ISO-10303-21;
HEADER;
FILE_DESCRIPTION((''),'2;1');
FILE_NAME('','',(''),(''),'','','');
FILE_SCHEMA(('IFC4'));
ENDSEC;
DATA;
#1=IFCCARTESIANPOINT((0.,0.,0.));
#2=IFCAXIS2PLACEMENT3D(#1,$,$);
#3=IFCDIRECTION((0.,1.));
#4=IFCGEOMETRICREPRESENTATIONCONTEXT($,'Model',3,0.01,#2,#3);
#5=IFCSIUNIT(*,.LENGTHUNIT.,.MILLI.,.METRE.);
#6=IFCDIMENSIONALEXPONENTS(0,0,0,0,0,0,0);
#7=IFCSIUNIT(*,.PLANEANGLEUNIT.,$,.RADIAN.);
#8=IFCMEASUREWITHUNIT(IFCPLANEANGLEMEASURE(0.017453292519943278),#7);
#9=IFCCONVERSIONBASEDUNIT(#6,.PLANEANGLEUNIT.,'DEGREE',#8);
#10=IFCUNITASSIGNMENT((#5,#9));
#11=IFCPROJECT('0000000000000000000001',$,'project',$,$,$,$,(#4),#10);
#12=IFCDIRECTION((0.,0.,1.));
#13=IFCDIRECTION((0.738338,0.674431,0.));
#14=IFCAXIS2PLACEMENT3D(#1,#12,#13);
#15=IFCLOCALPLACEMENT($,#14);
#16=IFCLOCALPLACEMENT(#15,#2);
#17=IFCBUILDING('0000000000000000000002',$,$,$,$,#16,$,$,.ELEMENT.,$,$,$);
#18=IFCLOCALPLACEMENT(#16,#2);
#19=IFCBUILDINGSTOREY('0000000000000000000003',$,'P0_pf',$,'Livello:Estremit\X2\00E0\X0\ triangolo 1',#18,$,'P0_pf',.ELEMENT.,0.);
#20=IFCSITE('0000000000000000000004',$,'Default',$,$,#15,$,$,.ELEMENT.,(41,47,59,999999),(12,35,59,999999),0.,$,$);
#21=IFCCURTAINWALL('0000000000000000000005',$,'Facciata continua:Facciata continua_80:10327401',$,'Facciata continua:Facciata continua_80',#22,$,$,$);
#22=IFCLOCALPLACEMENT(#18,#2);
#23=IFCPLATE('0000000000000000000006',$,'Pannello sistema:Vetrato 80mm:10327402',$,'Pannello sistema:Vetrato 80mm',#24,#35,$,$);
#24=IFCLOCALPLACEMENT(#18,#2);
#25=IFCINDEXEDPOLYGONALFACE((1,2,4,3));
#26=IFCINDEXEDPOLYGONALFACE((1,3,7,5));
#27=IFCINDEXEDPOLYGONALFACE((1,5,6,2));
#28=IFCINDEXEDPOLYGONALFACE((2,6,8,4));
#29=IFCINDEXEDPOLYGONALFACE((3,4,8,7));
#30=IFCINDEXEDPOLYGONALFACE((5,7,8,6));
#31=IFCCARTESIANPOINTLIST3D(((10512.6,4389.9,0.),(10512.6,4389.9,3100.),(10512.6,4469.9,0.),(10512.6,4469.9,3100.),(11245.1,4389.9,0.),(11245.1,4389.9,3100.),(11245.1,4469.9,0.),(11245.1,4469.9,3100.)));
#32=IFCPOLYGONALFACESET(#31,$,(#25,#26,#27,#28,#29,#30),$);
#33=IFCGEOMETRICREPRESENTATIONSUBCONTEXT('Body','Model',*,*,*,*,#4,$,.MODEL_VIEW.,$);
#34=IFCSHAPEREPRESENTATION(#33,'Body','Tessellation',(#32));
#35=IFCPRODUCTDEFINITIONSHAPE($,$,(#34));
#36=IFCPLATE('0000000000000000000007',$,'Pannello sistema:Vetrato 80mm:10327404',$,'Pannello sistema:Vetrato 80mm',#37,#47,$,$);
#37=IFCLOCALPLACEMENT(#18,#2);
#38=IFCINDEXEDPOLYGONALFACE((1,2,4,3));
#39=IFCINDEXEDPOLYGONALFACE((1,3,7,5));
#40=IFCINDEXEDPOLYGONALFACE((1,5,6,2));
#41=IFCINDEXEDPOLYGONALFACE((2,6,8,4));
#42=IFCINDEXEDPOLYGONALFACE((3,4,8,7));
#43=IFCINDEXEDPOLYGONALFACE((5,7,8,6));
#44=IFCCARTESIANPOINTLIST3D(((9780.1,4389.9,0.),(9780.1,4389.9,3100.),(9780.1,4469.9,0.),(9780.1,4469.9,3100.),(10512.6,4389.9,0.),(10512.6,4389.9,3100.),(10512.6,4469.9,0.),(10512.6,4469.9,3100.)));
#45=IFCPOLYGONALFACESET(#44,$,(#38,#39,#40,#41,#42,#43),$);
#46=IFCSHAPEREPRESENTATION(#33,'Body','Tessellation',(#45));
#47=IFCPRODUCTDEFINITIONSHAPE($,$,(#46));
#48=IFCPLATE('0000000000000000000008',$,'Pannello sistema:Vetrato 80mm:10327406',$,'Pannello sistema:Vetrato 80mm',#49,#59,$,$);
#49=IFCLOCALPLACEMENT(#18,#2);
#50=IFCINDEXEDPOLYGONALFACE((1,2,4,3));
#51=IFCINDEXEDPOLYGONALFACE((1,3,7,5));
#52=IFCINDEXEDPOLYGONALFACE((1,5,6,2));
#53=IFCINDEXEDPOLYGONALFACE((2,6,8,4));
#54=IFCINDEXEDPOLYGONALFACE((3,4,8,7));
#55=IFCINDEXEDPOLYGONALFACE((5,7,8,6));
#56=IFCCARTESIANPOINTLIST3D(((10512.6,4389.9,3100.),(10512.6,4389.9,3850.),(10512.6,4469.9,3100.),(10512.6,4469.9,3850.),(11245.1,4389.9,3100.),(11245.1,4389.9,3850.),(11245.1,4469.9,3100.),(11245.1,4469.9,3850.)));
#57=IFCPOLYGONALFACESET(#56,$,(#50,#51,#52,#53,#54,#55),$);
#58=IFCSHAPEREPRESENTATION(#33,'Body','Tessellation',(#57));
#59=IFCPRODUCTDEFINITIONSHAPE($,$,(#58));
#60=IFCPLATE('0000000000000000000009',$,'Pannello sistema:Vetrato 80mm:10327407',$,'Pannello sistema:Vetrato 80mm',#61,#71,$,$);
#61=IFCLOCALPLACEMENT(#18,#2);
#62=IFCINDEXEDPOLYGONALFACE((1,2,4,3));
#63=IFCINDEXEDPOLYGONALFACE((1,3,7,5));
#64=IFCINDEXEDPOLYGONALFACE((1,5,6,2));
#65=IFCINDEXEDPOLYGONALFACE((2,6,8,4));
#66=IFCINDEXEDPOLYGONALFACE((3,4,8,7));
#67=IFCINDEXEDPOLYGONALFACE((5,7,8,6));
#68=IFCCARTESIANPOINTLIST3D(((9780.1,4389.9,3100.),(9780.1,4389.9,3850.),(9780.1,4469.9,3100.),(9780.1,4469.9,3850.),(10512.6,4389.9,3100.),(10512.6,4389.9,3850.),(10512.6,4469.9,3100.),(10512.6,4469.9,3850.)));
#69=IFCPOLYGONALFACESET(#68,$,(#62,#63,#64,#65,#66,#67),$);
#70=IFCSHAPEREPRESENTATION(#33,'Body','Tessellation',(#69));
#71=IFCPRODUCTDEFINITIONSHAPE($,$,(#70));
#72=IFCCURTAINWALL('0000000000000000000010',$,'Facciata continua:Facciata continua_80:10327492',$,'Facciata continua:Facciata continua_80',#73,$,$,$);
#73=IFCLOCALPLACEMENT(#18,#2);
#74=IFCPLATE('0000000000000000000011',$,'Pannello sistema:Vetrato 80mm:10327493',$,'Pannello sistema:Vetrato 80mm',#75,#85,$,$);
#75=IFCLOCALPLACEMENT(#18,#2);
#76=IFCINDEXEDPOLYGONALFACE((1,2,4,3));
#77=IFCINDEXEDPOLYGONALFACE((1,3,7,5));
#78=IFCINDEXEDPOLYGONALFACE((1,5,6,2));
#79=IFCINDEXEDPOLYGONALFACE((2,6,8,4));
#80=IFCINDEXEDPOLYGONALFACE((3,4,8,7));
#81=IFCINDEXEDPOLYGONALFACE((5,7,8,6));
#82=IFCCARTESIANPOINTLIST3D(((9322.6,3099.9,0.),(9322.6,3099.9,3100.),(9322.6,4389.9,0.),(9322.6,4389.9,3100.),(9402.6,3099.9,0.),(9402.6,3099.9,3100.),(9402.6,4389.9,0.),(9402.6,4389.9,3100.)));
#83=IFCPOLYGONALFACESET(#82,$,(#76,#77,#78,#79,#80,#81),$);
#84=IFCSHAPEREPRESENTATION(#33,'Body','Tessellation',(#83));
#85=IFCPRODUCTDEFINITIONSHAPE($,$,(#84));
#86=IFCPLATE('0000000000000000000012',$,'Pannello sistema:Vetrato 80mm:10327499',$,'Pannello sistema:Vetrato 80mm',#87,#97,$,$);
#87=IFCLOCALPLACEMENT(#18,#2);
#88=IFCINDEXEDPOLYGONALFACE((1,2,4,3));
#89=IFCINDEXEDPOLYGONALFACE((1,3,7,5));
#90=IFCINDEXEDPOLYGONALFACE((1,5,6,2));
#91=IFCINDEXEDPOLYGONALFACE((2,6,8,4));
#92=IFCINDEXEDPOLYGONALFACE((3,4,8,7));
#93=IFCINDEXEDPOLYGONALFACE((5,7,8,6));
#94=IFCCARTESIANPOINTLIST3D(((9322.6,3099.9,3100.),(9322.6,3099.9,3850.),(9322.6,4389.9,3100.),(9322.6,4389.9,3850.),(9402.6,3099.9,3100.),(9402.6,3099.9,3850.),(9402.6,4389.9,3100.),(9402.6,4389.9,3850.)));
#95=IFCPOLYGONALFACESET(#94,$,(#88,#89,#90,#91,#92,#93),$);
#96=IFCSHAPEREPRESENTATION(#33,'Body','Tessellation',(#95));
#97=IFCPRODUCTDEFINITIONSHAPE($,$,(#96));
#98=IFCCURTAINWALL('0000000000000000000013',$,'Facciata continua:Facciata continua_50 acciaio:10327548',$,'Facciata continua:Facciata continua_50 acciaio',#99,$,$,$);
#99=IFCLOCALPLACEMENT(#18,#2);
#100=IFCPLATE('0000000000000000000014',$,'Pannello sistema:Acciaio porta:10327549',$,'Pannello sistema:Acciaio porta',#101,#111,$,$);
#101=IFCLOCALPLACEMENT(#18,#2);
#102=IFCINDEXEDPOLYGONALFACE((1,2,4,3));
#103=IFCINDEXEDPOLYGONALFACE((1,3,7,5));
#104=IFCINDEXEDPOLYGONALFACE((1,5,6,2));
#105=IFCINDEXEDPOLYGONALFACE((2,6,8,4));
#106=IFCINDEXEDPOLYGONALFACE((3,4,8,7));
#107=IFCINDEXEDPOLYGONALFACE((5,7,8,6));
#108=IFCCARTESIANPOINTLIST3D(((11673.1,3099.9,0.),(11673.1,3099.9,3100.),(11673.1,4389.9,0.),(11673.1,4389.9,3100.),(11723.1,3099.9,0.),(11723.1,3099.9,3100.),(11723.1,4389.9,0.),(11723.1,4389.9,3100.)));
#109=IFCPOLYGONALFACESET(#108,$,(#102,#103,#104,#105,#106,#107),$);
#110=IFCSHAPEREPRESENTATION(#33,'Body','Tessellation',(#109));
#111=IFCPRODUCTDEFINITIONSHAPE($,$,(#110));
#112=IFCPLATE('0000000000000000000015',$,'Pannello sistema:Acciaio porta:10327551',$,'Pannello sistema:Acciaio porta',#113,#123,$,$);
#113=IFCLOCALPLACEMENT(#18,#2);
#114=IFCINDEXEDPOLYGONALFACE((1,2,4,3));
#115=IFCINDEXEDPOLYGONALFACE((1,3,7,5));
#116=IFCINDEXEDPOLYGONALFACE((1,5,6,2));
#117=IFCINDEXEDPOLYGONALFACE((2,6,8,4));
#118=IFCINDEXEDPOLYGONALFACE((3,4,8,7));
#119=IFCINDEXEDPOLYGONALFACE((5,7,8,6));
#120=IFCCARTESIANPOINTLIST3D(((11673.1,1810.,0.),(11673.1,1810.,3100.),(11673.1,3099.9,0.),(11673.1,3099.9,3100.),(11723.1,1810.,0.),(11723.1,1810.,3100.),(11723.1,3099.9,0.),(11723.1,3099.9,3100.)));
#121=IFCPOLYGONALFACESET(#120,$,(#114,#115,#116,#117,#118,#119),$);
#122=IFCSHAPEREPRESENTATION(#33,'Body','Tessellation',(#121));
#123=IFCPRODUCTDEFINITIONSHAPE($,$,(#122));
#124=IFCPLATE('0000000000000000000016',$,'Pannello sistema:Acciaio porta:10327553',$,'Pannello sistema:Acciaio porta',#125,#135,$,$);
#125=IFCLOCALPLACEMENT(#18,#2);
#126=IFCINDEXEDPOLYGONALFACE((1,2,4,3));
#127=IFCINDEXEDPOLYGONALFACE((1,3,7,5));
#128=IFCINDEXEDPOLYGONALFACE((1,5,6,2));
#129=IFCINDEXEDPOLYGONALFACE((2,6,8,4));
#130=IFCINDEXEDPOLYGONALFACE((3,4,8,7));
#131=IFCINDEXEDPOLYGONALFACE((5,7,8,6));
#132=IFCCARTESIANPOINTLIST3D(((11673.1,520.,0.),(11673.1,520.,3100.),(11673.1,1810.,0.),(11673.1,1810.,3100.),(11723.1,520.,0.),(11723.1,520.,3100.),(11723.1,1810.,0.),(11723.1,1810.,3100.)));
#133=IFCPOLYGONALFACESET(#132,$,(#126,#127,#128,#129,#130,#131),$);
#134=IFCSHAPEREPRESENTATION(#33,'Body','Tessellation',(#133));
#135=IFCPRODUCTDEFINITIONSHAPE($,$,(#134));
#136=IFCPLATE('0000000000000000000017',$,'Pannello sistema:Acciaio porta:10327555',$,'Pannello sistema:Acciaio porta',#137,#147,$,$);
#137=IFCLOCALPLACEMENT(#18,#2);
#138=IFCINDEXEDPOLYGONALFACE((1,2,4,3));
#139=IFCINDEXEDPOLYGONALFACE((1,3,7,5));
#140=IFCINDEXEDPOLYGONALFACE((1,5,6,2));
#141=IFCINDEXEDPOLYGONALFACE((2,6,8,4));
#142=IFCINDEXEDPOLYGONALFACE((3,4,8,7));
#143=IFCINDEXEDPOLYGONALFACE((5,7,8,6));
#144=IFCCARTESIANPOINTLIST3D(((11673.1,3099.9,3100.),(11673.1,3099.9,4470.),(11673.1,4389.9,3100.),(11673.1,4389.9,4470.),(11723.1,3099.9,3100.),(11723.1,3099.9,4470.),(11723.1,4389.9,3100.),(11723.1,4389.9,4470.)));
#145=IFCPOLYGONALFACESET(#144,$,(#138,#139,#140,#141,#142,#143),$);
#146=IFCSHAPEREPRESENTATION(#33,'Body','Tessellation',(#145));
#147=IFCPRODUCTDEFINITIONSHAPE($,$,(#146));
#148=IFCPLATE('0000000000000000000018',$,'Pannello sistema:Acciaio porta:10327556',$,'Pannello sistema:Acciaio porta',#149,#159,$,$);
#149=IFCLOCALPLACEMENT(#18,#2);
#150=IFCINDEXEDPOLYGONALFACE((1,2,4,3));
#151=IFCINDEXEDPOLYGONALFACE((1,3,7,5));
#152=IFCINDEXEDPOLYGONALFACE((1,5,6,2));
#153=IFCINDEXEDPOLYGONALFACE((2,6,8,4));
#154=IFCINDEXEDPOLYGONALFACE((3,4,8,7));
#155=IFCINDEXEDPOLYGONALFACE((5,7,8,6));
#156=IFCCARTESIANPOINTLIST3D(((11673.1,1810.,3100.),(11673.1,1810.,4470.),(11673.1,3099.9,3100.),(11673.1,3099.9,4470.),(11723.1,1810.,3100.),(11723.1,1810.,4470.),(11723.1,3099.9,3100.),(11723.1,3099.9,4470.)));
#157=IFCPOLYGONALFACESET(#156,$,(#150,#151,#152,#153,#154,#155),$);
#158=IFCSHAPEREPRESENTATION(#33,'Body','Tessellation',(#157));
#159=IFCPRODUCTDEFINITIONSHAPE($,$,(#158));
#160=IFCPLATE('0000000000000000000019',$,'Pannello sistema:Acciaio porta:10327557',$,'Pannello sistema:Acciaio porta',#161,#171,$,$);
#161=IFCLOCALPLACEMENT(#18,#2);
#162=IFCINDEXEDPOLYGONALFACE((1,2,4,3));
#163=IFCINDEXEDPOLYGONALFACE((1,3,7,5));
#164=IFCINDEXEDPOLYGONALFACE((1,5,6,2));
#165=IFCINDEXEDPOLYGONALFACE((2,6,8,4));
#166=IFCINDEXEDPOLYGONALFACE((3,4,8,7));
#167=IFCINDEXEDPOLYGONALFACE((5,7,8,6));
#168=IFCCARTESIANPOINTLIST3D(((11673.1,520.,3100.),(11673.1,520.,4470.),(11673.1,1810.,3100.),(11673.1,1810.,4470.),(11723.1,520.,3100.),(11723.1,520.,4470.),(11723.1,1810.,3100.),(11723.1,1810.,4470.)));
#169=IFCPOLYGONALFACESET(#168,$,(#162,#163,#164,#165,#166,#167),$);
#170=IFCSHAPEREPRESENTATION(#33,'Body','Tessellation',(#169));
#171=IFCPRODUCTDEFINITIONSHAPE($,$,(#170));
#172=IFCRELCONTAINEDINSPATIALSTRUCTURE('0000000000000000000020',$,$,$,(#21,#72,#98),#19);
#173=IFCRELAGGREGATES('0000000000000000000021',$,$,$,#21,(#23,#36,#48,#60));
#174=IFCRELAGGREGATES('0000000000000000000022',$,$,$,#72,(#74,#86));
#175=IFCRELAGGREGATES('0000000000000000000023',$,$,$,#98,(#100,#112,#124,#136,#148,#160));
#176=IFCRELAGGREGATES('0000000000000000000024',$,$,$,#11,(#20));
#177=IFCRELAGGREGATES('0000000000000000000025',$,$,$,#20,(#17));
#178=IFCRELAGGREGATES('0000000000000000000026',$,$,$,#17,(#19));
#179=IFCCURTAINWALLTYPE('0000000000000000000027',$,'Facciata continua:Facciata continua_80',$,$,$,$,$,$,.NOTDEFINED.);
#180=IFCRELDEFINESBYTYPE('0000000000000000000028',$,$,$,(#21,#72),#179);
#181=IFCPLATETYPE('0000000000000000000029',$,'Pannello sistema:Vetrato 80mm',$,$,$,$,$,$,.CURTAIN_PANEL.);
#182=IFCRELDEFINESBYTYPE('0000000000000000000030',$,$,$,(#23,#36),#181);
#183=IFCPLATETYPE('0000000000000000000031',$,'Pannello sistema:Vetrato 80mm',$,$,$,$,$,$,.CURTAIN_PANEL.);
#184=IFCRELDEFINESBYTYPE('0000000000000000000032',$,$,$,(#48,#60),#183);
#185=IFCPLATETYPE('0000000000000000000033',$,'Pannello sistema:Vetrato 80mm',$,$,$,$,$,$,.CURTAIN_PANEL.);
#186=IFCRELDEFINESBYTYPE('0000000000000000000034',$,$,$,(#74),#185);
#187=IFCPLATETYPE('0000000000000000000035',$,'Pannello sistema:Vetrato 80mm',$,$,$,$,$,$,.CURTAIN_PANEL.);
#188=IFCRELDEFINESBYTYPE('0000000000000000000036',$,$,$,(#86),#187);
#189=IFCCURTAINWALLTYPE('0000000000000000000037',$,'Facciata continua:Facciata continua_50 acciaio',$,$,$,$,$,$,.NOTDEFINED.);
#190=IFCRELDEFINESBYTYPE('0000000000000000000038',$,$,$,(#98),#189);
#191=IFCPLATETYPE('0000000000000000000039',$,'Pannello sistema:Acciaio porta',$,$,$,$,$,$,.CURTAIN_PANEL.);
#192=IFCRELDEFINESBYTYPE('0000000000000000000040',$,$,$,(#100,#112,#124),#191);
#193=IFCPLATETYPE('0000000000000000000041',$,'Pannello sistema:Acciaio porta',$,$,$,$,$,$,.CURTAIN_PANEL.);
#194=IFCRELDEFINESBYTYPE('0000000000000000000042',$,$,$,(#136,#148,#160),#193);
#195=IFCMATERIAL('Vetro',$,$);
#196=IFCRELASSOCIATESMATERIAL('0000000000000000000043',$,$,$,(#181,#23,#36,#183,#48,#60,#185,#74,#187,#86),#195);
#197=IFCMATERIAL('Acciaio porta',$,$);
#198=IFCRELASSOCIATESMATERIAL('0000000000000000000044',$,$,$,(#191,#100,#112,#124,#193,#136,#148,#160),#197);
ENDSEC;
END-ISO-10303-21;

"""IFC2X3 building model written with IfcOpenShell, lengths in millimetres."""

from ifc_helpers import new_model, entity, si_unit, converted_unit, direction, frame, origin, origin_2d_with_axis, place, context, subcontext, project, spatial, rectangle, extrude, source, transform, mapped, material, type_object, type_shapes, element, aggregate, save


model = new_model("IFC2X3")

# Units and contexts
model_context = context("Model", 3, precision=0.01, world=origin(), true_north=direction((0.0, 1.0)))
body_context = subcontext(model_context, "Body", "Model", "MODEL_VIEW")
ifc_project = project(units=[si_unit("LENGTHUNIT", "METRE", prefix="MILLI"), converted_unit("PLANEANGLEUNIT", "DEGREE", entity("IfcPlaneAngleMeasure", 0.017453292519943278), si_unit("PLANEANGLEUNIT", "RADIAN"), dimensions=[0, 0, 0, 0, 0, 0, 0])], contexts=[model_context])

# Site, building, storey
site_placement = place(None, frame((0.0, 0.0, 0.0), z_axis=(0.0, 0.0, 1.0), x_axis=(0.738338, 0.674431, 0.0)))
site = spatial("IfcSite", under=ifc_project, at=site_placement, Name="Default", CompositionType="ELEMENT", RefLatitude=(41, 47, 59, 999999), RefLongitude=(12, 35, 59, 999999), RefElevation=0.0)
building_placement = place(site_placement, origin())
building = spatial("IfcBuilding", under=site, at=building_placement, CompositionType="ELEMENT")
storey_placement = place(building_placement, origin())
storey = spatial("IfcBuildingStorey", under=building, at=storey_placement, Name="P0_pf", ObjectType="Livello:Estremità triangolo 1", LongName="P0_pf", CompositionType="ELEMENT", Elevation=0.0)

# Curtain walls, plates
curtain_wall_type_1 = type_object("IfcCurtainWallType", Name="Facciata continua:Facciata continua_80", PredefinedType="NOTDEFINED")
curtain_wall_1_placement = place(storey_placement, origin())
curtain_wall_1 = element("IfcCurtainWall", 1, at=curtain_wall_1_placement, inside=storey, type_object=curtain_wall_type_1, Name="Facciata continua:Facciata continua_80:10327401", ObjectType="Facciata continua:Facciata continua_80")
ifc_material_1 = material(Name="Vetro")
plate_type_1 = type_object("IfcPlateType", Name="Pannello sistema:Vetrato 80mm", PredefinedType="CURTAIN_PANEL", material=ifc_material_1)
shared_shape_1 = source(origin(), body_context, "Body", "SweptSolid", [
    extrude(rectangle(XDim=80.0, YDim=732.5, at=origin_2d_with_axis()), frame((0.0, -40.0, 0.0), z_axis=(0.0, 0.0, 1.0), x_axis=(0.0, 1.0, 0.0)), (0.0, 0.0, 1.0), 3100.0),
])
type_shapes(plate_type_1, [shared_shape_1])
plate_1_placement = place(curtain_wall_1_placement, frame((10878.8, 4389.9, 0.0), z_axis=(0.0, 0.0, 1.0), x_axis=(-1.0, 0.0, 0.0)))
plate_1 = element("IfcPlate", 2, at=plate_1_placement, type_object=plate_type_1, material=ifc_material_1, Name="Pannello sistema:Vetrato 80mm:10327402", ObjectType="Pannello sistema:Vetrato 80mm", context=body_context, shape_type="MappedRepresentation", body=[
    mapped(shared_shape_1, transform((0.0, 0.0, 0.0), scale=1.0)),
])
plate_2_placement = place(curtain_wall_1_placement, frame((10146.3, 4389.9, 0.0), z_axis=(0.0, 0.0, 1.0), x_axis=(-1.0, 0.0, 0.0)))
plate_2 = element("IfcPlate", 3, at=plate_2_placement, type_object=plate_type_1, material=ifc_material_1, Name="Pannello sistema:Vetrato 80mm:10327404", ObjectType="Pannello sistema:Vetrato 80mm", context=body_context, shape_type="MappedRepresentation", body=[
    mapped(shared_shape_1, transform((0.0, 0.0, 0.0), scale=1.0)),
])
plate_type_2 = type_object("IfcPlateType", Name="Pannello sistema:Vetrato 80mm", PredefinedType="CURTAIN_PANEL", material=ifc_material_1)
shared_shape_2 = source(origin(), body_context, "Body", "SweptSolid", [
    extrude(rectangle(XDim=80.0, YDim=732.5, at=origin_2d_with_axis()), frame((0.0, -40.0, 0.0), z_axis=(0.0, 0.0, 1.0), x_axis=(0.0, 1.0, 0.0)), (0.0, 0.0, 1.0), 750.0),
])
type_shapes(plate_type_2, [shared_shape_2])
plate_3_placement = place(curtain_wall_1_placement, frame((10878.8, 4389.9, 3100.0), z_axis=(0.0, 0.0, 1.0), x_axis=(-1.0, 0.0, 0.0)))
plate_3 = element("IfcPlate", 4, at=plate_3_placement, type_object=plate_type_2, material=ifc_material_1, Name="Pannello sistema:Vetrato 80mm:10327406", ObjectType="Pannello sistema:Vetrato 80mm", context=body_context, shape_type="MappedRepresentation", body=[
    mapped(shared_shape_2, transform((0.0, 0.0, 0.0), scale=1.0)),
])
plate_4_placement = place(curtain_wall_1_placement, frame((10146.3, 4389.9, 3100.0), z_axis=(0.0, 0.0, 1.0), x_axis=(-1.0, 0.0, 0.0)))
plate_4 = element("IfcPlate", 5, at=plate_4_placement, type_object=plate_type_2, material=ifc_material_1, Name="Pannello sistema:Vetrato 80mm:10327407", ObjectType="Pannello sistema:Vetrato 80mm", context=body_context, shape_type="MappedRepresentation", body=[
    mapped(shared_shape_2, transform((0.0, 0.0, 0.0), scale=1.0)),
])
aggregate(curtain_wall_1, [plate_1, plate_2, plate_3, plate_4])
curtain_wall_2_placement = place(storey_placement, origin())
curtain_wall_2 = element("IfcCurtainWall", 6, at=curtain_wall_2_placement, inside=storey, type_object=curtain_wall_type_1, Name="Facciata continua:Facciata continua_80:10327492", ObjectType="Facciata continua:Facciata continua_80")
plate_type_3 = type_object("IfcPlateType", Name="Pannello sistema:Vetrato 80mm", PredefinedType="CURTAIN_PANEL", material=ifc_material_1)
shared_shape_3 = source(origin(), body_context, "Body", "SweptSolid", [
    extrude(rectangle(XDim=80.0, YDim=1290.0, at=origin_2d_with_axis()), frame((0.0, -40.0, 0.0), z_axis=(0.0, 0.0, 1.0), x_axis=(0.0, 1.0, 0.0)), (0.0, 0.0, 1.0), 3100.0),
])
type_shapes(plate_type_3, [shared_shape_3])
plate_5_placement = place(curtain_wall_2_placement, frame((9402.6, 3744.9, 0.0), z_axis=(0.0, 0.0, 1.0), x_axis=(0.0, -1.0, 0.0)))
plate_5 = element("IfcPlate", 7, at=plate_5_placement, type_object=plate_type_3, material=ifc_material_1, Name="Pannello sistema:Vetrato 80mm:10327493", ObjectType="Pannello sistema:Vetrato 80mm", context=body_context, shape_type="MappedRepresentation", body=[
    mapped(shared_shape_3, transform((0.0, 0.0, 0.0), scale=1.0)),
])
plate_type_4 = type_object("IfcPlateType", Name="Pannello sistema:Vetrato 80mm", PredefinedType="CURTAIN_PANEL", material=ifc_material_1)
shared_shape_4 = source(origin(), body_context, "Body", "SweptSolid", [
    extrude(rectangle(XDim=80.0, YDim=1290.0, at=origin_2d_with_axis()), frame((0.0, -40.0, 0.0), z_axis=(0.0, 0.0, 1.0), x_axis=(0.0, 1.0, 0.0)), (0.0, 0.0, 1.0), 750.0),
])
type_shapes(plate_type_4, [shared_shape_4])
plate_6_placement = place(curtain_wall_2_placement, frame((9402.6, 3744.9, 3100.0), z_axis=(0.0, 0.0, 1.0), x_axis=(0.0, -1.0, 0.0)))
plate_6 = element("IfcPlate", 8, at=plate_6_placement, type_object=plate_type_4, material=ifc_material_1, Name="Pannello sistema:Vetrato 80mm:10327499", ObjectType="Pannello sistema:Vetrato 80mm", context=body_context, shape_type="MappedRepresentation", body=[
    mapped(shared_shape_4, transform((0.0, 0.0, 0.0), scale=1.0)),
])
aggregate(curtain_wall_2, [plate_5, plate_6])
curtain_wall_type_2 = type_object("IfcCurtainWallType", Name="Facciata continua:Facciata continua_50 acciaio", PredefinedType="NOTDEFINED")
curtain_wall_3_placement = place(storey_placement, origin())
curtain_wall_3 = element("IfcCurtainWall", 9, at=curtain_wall_3_placement, inside=storey, type_object=curtain_wall_type_2, Name="Facciata continua:Facciata continua_50 acciaio:10327548", ObjectType="Facciata continua:Facciata continua_50 acciaio")
ifc_material_2 = material(Name="Acciaio porta")
plate_type_5 = type_object("IfcPlateType", Name="Pannello sistema:Acciaio porta", PredefinedType="CURTAIN_PANEL", material=ifc_material_2)
shared_shape_5 = source(origin(), body_context, "Body", "SweptSolid", [
    extrude(rectangle(XDim=50.0, YDim=1290.0, at=origin_2d_with_axis()), frame((0.0, 0.0, 0.0), z_axis=(0.0, 0.0, 1.0), x_axis=(0.0, 1.0, 0.0)), (0.0, 0.0, 1.0), 3100.0),
])
type_shapes(plate_type_5, [shared_shape_5])
plate_7_placement = place(curtain_wall_3_placement, frame((11698.1, 3744.9, 0.0), z_axis=(0.0, 0.0, 1.0), x_axis=(0.0, -1.0, 0.0)))
plate_7 = element("IfcPlate", 10, at=plate_7_placement, type_object=plate_type_5, material=ifc_material_2, Name="Pannello sistema:Acciaio porta:10327549", ObjectType="Pannello sistema:Acciaio porta", context=body_context, shape_type="MappedRepresentation", body=[
    mapped(shared_shape_5, transform((0.0, 0.0, 0.0), scale=1.0)),
])
plate_8_placement = place(curtain_wall_3_placement, frame((11698.1, 2455.0, 0.0), z_axis=(0.0, 0.0, 1.0), x_axis=(0.0, -1.0, 0.0)))
plate_8 = element("IfcPlate", 11, at=plate_8_placement, type_object=plate_type_5, material=ifc_material_2, Name="Pannello sistema:Acciaio porta:10327551", ObjectType="Pannello sistema:Acciaio porta", context=body_context, shape_type="MappedRepresentation", body=[
    mapped(shared_shape_5, transform((0.0, 0.0, 0.0), scale=1.0)),
])
plate_9_placement = place(curtain_wall_3_placement, frame((11698.1, 1165.0, 0.0), z_axis=(0.0, 0.0, 1.0), x_axis=(0.0, -1.0, 0.0)))
plate_9 = element("IfcPlate", 12, at=plate_9_placement, type_object=plate_type_5, material=ifc_material_2, Name="Pannello sistema:Acciaio porta:10327553", ObjectType="Pannello sistema:Acciaio porta", context=body_context, shape_type="MappedRepresentation", body=[
    mapped(shared_shape_5, transform((0.0, 0.0, 0.0), scale=1.0)),
])
plate_type_6 = type_object("IfcPlateType", Name="Pannello sistema:Acciaio porta", PredefinedType="CURTAIN_PANEL", material=ifc_material_2)
shared_shape_6 = source(origin(), body_context, "Body", "SweptSolid", [
    extrude(rectangle(XDim=50.0, YDim=1290.0, at=origin_2d_with_axis()), frame((0.0, 0.0, 0.0), z_axis=(0.0, 0.0, 1.0), x_axis=(0.0, 1.0, 0.0)), (0.0, 0.0, 1.0), 1370.0),
])
type_shapes(plate_type_6, [shared_shape_6])
plate_10_placement = place(curtain_wall_3_placement, frame((11698.1, 3744.9, 3100.0), z_axis=(0.0, 0.0, 1.0), x_axis=(0.0, -1.0, 0.0)))
plate_10 = element("IfcPlate", 13, at=plate_10_placement, type_object=plate_type_6, material=ifc_material_2, Name="Pannello sistema:Acciaio porta:10327555", ObjectType="Pannello sistema:Acciaio porta", context=body_context, shape_type="MappedRepresentation", body=[
    mapped(shared_shape_6, transform((0.0, 0.0, 0.0), scale=1.0)),
])
plate_11_placement = place(curtain_wall_3_placement, frame((11698.1, 2455.0, 3100.0), z_axis=(0.0, 0.0, 1.0), x_axis=(0.0, -1.0, 0.0)))
plate_11 = element("IfcPlate", 14, at=plate_11_placement, type_object=plate_type_6, material=ifc_material_2, Name="Pannello sistema:Acciaio porta:10327556", ObjectType="Pannello sistema:Acciaio porta", context=body_context, shape_type="MappedRepresentation", body=[
    mapped(shared_shape_6, transform((0.0, 0.0, 0.0), scale=1.0)),
])
plate_12_placement = place(curtain_wall_3_placement, frame((11698.1, 1165.0, 3100.0), z_axis=(0.0, 0.0, 1.0), x_axis=(0.0, -1.0, 0.0)))
plate_12 = element("IfcPlate", 15, at=plate_12_placement, type_object=plate_type_6, material=ifc_material_2, Name="Pannello sistema:Acciaio porta:10327557", ObjectType="Pannello sistema:Acciaio porta", context=body_context, shape_type="MappedRepresentation", body=[
    mapped(shared_shape_6, transform((0.0, 0.0, 0.0), scale=1.0)),
])
aggregate(curtain_wall_3, [plate_7, plate_8, plate_9, plate_10, plate_11, plate_12])

save(model, "model.ifc")
